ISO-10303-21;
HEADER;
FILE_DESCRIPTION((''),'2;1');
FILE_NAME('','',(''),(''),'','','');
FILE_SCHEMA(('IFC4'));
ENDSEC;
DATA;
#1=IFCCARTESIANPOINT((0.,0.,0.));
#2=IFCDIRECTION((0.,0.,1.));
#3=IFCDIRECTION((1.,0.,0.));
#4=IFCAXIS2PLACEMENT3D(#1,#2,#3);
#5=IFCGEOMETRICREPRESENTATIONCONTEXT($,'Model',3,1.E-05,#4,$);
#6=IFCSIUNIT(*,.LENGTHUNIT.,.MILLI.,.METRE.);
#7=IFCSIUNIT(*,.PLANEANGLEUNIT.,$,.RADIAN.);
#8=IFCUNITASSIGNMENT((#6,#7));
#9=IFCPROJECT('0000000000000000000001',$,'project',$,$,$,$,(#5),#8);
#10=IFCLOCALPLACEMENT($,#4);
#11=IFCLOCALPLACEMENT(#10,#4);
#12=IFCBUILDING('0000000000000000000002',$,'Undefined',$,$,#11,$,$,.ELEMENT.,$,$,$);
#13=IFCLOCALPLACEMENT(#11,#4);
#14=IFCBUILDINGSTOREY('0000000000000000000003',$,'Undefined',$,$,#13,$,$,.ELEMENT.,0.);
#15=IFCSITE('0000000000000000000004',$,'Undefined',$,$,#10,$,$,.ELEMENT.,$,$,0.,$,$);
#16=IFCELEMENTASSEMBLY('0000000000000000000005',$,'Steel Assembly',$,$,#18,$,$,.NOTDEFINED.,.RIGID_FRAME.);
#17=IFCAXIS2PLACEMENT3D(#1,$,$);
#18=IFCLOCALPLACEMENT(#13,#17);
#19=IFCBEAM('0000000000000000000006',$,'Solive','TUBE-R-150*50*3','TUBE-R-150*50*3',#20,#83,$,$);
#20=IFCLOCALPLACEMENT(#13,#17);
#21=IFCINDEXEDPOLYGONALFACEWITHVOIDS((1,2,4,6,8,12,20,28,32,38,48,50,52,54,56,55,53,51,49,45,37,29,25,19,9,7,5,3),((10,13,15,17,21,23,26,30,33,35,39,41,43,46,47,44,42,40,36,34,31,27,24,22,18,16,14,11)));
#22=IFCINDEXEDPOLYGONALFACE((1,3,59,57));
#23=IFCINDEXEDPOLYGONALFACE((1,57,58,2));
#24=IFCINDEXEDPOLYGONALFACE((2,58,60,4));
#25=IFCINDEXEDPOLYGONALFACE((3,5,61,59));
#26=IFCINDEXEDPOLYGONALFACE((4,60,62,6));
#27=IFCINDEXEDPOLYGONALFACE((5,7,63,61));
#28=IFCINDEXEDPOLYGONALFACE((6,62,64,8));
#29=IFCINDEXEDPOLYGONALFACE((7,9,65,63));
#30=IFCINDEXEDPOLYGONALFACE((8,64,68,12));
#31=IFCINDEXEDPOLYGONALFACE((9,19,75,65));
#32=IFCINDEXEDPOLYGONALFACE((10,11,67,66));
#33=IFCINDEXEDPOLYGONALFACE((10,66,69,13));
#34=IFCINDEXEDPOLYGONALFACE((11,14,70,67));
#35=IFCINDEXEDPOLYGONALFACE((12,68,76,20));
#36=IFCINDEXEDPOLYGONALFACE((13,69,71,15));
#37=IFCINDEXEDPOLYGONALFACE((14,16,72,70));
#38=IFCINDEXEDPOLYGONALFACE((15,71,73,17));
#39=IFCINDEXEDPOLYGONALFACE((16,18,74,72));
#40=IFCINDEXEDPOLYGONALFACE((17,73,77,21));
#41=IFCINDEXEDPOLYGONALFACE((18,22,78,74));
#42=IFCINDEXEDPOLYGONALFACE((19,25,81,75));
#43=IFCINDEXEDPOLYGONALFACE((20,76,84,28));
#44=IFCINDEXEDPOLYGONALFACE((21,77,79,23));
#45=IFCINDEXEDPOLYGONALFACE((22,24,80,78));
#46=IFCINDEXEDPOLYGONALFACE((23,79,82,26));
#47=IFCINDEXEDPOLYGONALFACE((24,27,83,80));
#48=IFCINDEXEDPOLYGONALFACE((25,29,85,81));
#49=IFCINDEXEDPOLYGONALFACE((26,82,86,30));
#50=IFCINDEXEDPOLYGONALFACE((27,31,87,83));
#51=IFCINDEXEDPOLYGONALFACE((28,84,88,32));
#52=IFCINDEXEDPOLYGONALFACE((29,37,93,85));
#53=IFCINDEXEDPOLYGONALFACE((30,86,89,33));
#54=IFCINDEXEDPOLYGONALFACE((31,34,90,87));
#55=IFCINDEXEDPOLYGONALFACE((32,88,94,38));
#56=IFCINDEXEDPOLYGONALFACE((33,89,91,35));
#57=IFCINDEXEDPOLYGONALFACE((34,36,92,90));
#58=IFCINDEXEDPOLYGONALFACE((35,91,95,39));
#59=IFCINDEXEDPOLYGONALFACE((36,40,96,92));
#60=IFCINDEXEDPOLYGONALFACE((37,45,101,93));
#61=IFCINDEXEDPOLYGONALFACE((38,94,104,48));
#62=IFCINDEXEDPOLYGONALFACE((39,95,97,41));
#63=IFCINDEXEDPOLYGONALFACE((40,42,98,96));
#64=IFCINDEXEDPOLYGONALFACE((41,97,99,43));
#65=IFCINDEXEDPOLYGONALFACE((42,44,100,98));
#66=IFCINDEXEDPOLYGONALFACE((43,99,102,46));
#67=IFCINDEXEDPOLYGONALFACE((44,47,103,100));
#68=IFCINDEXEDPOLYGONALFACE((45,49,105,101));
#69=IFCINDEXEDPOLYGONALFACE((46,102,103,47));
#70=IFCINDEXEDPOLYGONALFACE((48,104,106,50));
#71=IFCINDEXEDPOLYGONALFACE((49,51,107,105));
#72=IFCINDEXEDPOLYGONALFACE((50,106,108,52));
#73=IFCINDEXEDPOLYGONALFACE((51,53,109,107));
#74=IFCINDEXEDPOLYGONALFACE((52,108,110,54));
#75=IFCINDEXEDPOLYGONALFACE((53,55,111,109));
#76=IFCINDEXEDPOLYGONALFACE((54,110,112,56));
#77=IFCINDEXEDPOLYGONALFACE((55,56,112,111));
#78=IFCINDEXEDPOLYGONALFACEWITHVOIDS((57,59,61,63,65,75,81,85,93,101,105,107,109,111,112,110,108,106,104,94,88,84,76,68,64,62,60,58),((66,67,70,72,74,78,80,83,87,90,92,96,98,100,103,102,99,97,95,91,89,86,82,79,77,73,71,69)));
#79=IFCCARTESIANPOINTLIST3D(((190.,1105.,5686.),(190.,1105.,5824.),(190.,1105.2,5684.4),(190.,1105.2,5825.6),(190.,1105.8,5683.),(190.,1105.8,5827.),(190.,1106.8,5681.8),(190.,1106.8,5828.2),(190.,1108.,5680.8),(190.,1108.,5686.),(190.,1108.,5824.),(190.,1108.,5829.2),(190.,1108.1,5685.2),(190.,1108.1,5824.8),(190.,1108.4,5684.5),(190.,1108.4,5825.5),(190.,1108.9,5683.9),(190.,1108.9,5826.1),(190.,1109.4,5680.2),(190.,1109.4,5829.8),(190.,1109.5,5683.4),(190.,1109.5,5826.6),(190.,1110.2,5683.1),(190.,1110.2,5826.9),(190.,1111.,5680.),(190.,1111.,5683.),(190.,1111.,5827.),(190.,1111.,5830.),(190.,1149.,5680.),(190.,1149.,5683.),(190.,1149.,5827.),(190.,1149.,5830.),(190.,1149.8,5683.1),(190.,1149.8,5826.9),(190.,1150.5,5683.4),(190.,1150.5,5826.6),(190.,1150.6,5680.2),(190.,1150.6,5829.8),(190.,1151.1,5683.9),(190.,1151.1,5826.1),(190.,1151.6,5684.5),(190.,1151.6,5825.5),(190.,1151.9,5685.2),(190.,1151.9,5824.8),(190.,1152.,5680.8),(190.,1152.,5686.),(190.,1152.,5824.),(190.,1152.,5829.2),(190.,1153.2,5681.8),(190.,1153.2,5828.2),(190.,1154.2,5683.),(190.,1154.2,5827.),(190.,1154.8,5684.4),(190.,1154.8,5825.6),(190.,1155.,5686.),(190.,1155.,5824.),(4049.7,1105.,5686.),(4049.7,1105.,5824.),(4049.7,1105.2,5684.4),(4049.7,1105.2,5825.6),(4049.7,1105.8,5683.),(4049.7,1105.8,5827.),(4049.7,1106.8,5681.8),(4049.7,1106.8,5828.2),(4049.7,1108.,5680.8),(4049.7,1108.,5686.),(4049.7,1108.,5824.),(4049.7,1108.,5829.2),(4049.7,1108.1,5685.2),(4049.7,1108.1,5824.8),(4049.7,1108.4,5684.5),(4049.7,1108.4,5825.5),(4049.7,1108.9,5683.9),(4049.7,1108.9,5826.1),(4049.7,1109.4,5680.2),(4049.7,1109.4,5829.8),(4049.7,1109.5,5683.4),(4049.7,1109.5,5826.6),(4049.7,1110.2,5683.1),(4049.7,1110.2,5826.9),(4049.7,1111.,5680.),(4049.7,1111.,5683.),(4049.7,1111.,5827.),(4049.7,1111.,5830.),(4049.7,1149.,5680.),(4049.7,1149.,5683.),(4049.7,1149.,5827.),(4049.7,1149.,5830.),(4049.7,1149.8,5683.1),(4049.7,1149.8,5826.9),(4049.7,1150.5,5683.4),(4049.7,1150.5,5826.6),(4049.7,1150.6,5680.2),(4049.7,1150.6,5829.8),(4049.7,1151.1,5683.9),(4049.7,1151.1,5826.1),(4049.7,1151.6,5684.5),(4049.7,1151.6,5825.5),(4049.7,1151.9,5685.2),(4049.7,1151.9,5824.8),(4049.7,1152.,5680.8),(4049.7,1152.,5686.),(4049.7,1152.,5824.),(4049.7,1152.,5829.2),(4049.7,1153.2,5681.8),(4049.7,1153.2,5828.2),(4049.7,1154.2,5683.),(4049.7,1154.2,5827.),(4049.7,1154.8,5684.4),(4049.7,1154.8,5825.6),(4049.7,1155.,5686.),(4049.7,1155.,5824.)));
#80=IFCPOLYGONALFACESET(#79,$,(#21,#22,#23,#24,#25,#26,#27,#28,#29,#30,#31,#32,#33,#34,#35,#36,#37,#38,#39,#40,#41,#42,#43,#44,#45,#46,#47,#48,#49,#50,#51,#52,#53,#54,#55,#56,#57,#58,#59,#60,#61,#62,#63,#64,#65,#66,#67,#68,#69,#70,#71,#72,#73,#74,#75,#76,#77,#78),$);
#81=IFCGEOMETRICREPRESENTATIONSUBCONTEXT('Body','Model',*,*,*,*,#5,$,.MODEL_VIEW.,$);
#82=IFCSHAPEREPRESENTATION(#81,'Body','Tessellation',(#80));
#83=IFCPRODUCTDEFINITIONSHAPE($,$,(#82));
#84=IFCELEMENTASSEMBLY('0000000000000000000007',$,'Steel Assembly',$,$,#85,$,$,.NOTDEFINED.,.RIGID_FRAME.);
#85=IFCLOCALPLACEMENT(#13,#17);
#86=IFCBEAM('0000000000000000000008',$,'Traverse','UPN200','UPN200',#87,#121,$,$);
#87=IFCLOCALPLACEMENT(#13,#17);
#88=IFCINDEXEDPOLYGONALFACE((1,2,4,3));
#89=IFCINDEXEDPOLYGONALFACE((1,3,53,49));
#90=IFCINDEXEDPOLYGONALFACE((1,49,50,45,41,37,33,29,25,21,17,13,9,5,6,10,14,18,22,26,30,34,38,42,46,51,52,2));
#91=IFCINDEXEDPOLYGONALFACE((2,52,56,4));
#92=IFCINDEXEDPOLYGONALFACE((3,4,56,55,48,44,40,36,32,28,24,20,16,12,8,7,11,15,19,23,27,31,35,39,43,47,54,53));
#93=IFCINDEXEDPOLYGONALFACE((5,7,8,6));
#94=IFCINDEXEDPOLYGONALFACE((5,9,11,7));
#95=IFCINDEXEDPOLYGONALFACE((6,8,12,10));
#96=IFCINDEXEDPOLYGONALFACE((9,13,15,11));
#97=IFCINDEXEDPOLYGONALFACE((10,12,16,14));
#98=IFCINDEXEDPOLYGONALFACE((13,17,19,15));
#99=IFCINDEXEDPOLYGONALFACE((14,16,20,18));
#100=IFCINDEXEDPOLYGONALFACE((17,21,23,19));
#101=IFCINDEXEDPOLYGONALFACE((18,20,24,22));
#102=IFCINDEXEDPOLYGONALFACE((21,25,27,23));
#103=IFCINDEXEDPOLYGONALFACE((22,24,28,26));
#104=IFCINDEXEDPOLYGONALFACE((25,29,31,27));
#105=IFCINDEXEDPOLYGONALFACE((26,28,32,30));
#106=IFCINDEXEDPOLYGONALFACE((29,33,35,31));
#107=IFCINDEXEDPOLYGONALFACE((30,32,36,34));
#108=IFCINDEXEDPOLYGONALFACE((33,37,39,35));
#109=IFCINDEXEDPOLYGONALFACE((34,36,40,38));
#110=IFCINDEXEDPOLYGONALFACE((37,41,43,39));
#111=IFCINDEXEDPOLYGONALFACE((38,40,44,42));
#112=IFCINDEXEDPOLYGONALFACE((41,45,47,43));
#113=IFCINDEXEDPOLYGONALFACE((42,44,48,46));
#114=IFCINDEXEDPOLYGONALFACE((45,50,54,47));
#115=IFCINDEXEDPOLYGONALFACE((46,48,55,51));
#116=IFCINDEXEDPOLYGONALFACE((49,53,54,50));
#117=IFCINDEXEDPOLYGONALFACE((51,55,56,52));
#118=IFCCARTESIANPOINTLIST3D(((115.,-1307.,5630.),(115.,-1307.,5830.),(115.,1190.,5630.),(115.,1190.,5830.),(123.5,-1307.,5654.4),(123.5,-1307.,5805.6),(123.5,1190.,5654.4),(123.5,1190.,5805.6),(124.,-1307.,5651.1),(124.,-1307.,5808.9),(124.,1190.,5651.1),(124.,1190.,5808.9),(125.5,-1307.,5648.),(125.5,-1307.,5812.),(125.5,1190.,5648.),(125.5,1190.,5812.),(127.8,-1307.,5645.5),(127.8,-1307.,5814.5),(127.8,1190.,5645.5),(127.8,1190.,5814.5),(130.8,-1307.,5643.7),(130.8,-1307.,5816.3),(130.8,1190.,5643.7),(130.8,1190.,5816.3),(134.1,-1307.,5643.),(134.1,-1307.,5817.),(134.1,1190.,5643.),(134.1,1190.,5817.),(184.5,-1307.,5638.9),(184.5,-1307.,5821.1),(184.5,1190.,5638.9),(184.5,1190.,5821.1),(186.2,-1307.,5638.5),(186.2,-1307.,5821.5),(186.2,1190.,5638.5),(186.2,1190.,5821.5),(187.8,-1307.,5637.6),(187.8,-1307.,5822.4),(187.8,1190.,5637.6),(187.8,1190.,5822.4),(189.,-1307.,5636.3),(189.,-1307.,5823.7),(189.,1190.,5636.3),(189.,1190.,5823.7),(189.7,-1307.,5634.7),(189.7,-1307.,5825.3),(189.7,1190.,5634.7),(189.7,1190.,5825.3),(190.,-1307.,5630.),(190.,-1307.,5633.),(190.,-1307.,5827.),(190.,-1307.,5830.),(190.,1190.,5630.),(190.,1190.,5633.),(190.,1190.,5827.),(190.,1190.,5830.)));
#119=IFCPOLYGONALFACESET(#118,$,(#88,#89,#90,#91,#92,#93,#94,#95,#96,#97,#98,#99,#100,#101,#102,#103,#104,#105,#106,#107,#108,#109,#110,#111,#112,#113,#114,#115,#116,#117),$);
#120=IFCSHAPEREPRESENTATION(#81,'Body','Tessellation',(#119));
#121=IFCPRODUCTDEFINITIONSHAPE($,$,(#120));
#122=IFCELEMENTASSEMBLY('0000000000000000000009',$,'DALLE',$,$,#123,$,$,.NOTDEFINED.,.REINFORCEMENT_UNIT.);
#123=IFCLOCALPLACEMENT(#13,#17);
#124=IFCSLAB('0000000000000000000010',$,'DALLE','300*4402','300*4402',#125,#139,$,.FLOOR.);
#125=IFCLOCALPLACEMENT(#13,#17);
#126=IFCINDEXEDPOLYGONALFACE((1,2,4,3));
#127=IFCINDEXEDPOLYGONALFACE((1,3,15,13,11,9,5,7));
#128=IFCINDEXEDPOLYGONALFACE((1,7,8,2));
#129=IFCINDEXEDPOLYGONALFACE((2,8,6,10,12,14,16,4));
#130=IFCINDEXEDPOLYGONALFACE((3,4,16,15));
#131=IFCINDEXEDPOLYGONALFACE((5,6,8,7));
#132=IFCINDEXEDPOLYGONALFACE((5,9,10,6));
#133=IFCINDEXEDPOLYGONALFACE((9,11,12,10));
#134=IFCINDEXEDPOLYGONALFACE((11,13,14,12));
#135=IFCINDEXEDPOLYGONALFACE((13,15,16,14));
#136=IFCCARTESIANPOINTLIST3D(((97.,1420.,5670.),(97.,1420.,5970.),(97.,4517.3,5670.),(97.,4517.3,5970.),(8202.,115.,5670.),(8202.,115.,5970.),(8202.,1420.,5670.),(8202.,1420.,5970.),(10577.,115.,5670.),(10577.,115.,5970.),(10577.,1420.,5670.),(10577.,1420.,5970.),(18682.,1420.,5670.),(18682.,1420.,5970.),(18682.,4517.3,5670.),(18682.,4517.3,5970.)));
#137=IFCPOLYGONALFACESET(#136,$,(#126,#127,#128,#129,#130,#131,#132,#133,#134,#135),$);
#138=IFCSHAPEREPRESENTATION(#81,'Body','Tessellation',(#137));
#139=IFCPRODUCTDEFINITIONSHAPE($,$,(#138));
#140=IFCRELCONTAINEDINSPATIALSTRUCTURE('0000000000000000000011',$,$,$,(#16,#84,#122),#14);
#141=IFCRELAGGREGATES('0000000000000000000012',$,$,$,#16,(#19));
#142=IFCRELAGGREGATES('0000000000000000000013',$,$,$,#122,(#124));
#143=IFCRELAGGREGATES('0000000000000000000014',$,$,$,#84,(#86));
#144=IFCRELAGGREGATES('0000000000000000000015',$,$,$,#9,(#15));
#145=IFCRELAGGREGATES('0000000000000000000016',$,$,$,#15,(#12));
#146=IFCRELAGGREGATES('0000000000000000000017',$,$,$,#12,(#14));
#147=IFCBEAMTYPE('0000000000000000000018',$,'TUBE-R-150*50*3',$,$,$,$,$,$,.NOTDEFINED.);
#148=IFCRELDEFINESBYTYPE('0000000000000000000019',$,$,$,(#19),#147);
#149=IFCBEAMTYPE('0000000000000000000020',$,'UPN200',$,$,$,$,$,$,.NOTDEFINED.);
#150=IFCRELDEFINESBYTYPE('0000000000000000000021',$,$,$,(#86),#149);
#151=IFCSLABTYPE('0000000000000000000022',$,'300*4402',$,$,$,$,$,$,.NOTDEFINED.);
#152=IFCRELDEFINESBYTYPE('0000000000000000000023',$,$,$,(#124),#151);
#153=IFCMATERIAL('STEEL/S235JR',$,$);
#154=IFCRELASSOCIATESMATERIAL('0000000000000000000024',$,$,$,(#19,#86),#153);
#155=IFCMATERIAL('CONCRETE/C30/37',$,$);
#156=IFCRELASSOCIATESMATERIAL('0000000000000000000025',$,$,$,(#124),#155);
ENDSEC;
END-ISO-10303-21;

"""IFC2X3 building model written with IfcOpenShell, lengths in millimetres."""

from ifc_helpers import new_model, si_unit, frame, origin_with_axes, origin_2d_with_axis, place, context, subcontext, project, spatial, polyline, hollow_rectangle, u_section, outline, extrude, material, type_object, element, aggregate, save


model = new_model("IFC2X3")

# Units and contexts
model_context = context("Model", 3, precision=1e-05, world=origin_with_axes())
body_context = subcontext(model_context, "Body", "Model", "MODEL_VIEW")
ifc_project = project(units=[si_unit("LENGTHUNIT", "METRE", prefix="MILLI"), si_unit("PLANEANGLEUNIT", "RADIAN")], contexts=[model_context])

# Site, building, storey
site_placement = place(None, origin_with_axes())
site = spatial("IfcSite", under=ifc_project, at=site_placement, Name="Undefined", CompositionType="ELEMENT", RefElevation=0.0)
building_placement = place(site_placement, origin_with_axes())
building = spatial("IfcBuilding", under=site, at=building_placement, Name="Undefined", CompositionType="ELEMENT")
storey_placement = place(building_placement, origin_with_axes())
storey = spatial("IfcBuildingStorey", under=building, at=storey_placement, Name="Undefined", CompositionType="ELEMENT", Elevation=0.0)

# Element assemblies, beams
ifc_material_1 = material(Name="STEEL/S235JR")
beam_type_1 = type_object("IfcBeamType", Name="TUBE-R-150*50*3", PredefinedType="NOTDEFINED")
assembly_1_placement = place(storey_placement, origin_with_axes())
assembly_1 = element("IfcElementAssembly", 1, at=assembly_1_placement, inside=storey, Name="Steel Assembly", AssemblyPlace="NOTDEFINED", PredefinedType="RIGID_FRAME")
beam_1_placement = place(assembly_1_placement, frame((190.0, 1130.0, 5755.0), z_axis=(0.0, 0.0, 1.0), x_axis=(1.0, 0.0, 0.0)))
beam_1 = element("IfcBeam", 2, at=beam_1_placement, type_object=beam_type_1, material=ifc_material_1, Name="Solive", Description="TUBE-R-150*50*3", ObjectType="TUBE-R-150*50*3", context=body_context, shape_type="SweptSolid", body=[
    extrude(hollow_rectangle(XDim=50.0, YDim=150.0, WallThickness=3.0, InnerFilletRadius=3.0, OuterFilletRadius=6.0, at=origin_2d_with_axis()), frame((3859.7, 0.0, 0.0), z_axis=(-1.0, 0.0, 0.0), x_axis=(0.0, -1.0, 0.0)), (0.0, 0.0, 1.0), 3859.7),
])
aggregate(assembly_1, [beam_1])
assembly_2_placement = place(storey_placement, origin_with_axes())
assembly_2 = element("IfcElementAssembly", 3, at=assembly_2_placement, inside=storey, Name="Steel Assembly", AssemblyPlace="NOTDEFINED", PredefinedType="RIGID_FRAME")
beam_type_2 = type_object("IfcBeamType", Name="UPN200", PredefinedType="NOTDEFINED")
beam_2_placement = place(assembly_2_placement, frame((152.5, 1190.0, 5730.0), z_axis=(0.0, 0.0, -1.0), x_axis=(0.0, -1.0, 0.0)))
beam_2 = element("IfcBeam", 4, at=beam_2_placement, type_object=beam_type_2, material=ifc_material_1, Name="Traverse", Description="UPN200", ObjectType="UPN200", context=body_context, shape_type="SweptSolid", body=[
    extrude(u_section(Depth=200.0, FlangeWidth=75.0, WebThickness=8.5, FlangeThickness=11.5, FilletRadius=11.5, EdgeRadius=6.0, FlangeSlope=0.07983, at=origin_2d_with_axis()), frame((2497.0, 0.0, 0.0), z_axis=(-1.0, 0.0, 0.0), x_axis=(0.0, -1.0, 0.0)), (0.0, 0.0, 1.0), 2497.0),
])

# Element assembly, slab
assembly_3_placement = place(storey_placement, origin_with_axes())
assembly_3 = element("IfcElementAssembly", 5, at=assembly_3_placement, inside=storey, Name="DALLE", AssemblyPlace="NOTDEFINED", PredefinedType="REINFORCEMENT_UNIT")
ifc_material_2 = material(Name="CONCRETE/C30/37")
slab_type = type_object("IfcSlabType", Name="300*4402", PredefinedType="NOTDEFINED")
slab_placement = place(assembly_3_placement, frame((97.0, 4517.3, 5820.0), z_axis=(0.0, 0.0, 1.0), x_axis=(0.0, -1.0, 0.0)))
slab = element("IfcSlab", 6, at=slab_placement, type_object=slab_type, material=ifc_material_2, Name="DALLE", Description="300*4402", ObjectType="300*4402", PredefinedType="FLOOR", context=body_context, shape_type="SweptSolid", body=[
    extrude(outline(polyline([(0.0, 0.0), (3097.3, 0.0), (3097.3, 8105.0), (4402.3, 8105.0), (4402.3, 10480.0), (3097.3, 10480.0), (3097.3, 18585.0), (0.0, 18585.0), (0.0, 0.0)])), frame((0.0, 0.0, -150.0), z_axis=(0.0, 0.0, 1.0), x_axis=(1.0, 0.0, 0.0)), (0.0, 0.0, 1.0), 300.0),
])
aggregate(assembly_3, [slab])

aggregate(assembly_2, [beam_2])

save(model, "model.ifc")
